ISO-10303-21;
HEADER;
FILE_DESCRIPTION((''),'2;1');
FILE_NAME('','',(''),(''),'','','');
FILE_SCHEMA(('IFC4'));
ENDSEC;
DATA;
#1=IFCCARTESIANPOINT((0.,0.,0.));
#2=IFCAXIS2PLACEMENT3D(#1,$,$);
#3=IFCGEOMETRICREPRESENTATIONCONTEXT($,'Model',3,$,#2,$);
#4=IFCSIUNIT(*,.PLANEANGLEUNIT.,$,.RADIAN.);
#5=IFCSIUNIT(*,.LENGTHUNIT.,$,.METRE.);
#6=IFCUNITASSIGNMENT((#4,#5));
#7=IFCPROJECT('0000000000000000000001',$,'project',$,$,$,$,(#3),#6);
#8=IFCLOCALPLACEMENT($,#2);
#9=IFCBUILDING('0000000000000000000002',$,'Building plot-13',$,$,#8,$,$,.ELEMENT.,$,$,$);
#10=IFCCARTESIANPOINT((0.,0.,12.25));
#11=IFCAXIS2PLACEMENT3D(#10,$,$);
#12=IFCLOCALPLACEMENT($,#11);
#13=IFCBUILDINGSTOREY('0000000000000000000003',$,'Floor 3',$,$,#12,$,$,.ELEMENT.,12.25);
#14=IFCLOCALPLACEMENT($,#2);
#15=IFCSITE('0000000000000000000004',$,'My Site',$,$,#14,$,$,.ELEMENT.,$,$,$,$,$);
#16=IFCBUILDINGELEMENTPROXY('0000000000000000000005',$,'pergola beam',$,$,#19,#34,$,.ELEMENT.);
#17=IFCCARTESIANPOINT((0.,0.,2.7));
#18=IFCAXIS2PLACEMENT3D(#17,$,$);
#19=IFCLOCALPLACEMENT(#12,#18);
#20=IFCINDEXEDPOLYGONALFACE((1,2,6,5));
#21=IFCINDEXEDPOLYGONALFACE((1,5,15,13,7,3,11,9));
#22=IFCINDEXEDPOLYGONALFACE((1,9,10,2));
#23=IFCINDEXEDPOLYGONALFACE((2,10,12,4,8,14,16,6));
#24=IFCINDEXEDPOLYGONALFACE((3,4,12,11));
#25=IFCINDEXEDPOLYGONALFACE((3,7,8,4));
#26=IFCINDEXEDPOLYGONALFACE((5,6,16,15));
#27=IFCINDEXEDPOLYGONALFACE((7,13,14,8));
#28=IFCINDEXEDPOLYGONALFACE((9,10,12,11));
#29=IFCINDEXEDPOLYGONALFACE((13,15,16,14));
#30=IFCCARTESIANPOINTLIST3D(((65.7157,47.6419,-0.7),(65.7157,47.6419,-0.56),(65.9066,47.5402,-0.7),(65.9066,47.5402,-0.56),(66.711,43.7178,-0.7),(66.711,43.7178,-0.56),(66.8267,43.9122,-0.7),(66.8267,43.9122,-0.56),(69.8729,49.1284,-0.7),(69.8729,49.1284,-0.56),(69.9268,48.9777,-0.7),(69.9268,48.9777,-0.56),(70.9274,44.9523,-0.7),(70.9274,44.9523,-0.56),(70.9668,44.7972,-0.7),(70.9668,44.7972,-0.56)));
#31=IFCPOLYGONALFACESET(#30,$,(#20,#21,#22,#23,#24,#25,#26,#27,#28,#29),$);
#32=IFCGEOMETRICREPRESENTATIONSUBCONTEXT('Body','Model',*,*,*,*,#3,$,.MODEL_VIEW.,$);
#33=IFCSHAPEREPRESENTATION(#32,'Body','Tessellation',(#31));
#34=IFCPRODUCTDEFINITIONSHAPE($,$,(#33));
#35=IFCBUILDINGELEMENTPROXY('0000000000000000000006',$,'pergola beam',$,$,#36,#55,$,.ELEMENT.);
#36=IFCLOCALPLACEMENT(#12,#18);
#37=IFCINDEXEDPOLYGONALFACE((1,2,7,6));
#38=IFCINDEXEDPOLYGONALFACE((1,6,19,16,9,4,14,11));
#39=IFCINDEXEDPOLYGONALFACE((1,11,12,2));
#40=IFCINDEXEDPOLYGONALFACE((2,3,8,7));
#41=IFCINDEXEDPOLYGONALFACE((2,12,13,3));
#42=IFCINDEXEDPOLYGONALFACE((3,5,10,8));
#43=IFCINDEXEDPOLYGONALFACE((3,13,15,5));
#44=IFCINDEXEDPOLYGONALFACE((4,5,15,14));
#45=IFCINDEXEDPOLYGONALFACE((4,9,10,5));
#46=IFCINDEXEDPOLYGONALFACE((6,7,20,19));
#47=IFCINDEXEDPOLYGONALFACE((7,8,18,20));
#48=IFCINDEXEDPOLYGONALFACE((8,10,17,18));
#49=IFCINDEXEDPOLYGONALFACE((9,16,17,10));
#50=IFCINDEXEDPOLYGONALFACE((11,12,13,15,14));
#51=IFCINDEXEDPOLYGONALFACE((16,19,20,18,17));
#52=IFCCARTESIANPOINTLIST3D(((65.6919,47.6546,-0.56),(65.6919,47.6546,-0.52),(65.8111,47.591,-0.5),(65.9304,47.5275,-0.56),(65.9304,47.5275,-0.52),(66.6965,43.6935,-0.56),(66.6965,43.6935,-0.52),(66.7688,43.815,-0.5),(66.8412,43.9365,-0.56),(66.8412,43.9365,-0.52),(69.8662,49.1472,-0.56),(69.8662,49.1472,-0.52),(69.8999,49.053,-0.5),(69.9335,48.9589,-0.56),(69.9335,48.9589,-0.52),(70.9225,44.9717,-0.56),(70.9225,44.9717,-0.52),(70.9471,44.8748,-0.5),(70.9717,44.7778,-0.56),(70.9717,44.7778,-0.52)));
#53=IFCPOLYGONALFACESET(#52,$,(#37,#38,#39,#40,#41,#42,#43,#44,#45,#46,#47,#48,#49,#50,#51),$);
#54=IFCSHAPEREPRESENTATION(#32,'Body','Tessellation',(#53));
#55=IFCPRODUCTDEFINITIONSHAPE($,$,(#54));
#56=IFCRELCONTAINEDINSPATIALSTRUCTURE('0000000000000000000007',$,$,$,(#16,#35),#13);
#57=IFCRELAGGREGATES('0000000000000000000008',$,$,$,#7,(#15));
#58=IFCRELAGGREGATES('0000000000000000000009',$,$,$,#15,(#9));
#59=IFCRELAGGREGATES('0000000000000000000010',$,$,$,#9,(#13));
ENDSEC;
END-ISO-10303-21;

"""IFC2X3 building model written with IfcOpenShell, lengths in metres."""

from ifc_helpers import new_model, entity, si_unit, frame, origin, place, context, subcontext, project, spatial, element, save


model = new_model("IFC2X3")

# Units and contexts
model_context = context("Model", 3, world=origin())
body_context = subcontext(model_context, "Body", "Model", "MODEL_VIEW")
ifc_project = project(units=[si_unit("PLANEANGLEUNIT", "RADIAN"), si_unit("LENGTHUNIT", "METRE")], contexts=[model_context])

# Site, building, storey
site_placement = place(None, origin())
site = spatial("IfcSite", under=ifc_project, at=site_placement, Name="My Site", CompositionType="ELEMENT")
building_placement = place(None, origin())
building = spatial("IfcBuilding", under=site, at=building_placement, Name="Building plot-13", CompositionType="ELEMENT")
storey_placement = place(None, frame((0.0, 0.0, 12.25)))
storey = spatial("IfcBuildingStorey", under=building, at=storey_placement, Name="Floor 3", CompositionType="ELEMENT", Elevation=12.25)

# Building element proxies
proxy_1_placement = place(storey_placement, frame((0.0, 0.0, 2.7)))
axis2_placement3_d_1 = entity("IfcAxis2Placement3D", entity("IfcCartesianPoint", [0.0, 0.0, 0.0]))
element("IfcBuildingElementProxy", 1, at=proxy_1_placement, inside=storey, Name="pergola beam", CompositionType="ELEMENT", context=body_context, shape_type="SweptSolid", held_by="IfcProductRepresentation", body=[
    entity("IfcSurfaceCurveSweptAreaSolid", entity("IfcArbitraryClosedProfileDef", "AREA", None, entity("IfcPolyline", [entity("IfcCartesianPoint", [-0.7, -0.08]), entity("IfcCartesianPoint", [-0.7, 0.08]), entity("IfcCartesianPoint", [-0.56, 0.08]), entity("IfcCartesianPoint", [-0.56, -0.08]), entity("IfcCartesianPoint", [-0.7, -0.08])])), axis2_placement3_d_1, entity("IfcPolyline", [entity("IfcCartesianPoint", [69.8999, 49.053]), entity("IfcCartesianPoint", [65.8111, 47.591]), entity("IfcCartesianPoint", [66.7688, 43.815]), entity("IfcCartesianPoint", [70.9471, 44.8748])]), 0.0, 1.0, entity("IfcPlane", axis2_placement3_d_1)),
])
proxy_2_placement = place(storey_placement, frame((0.0, 0.0, 2.7)))
axis2_placement3_d_2 = entity("IfcAxis2Placement3D", entity("IfcCartesianPoint", [0.0, 0.0, 0.0]))
element("IfcBuildingElementProxy", 2, at=proxy_2_placement, inside=storey, Name="pergola beam", CompositionType="ELEMENT", context=body_context, shape_type="SweptSolid", held_by="IfcProductRepresentation", body=[
    entity("IfcSurfaceCurveSweptAreaSolid", entity("IfcArbitraryClosedProfileDef", "AREA", None, entity("IfcPolyline", [entity("IfcCartesianPoint", [-0.5, 0.0]), entity("IfcCartesianPoint", [-0.52, -0.1]), entity("IfcCartesianPoint", [-0.56, -0.1]), entity("IfcCartesianPoint", [-0.56, 0.1]), entity("IfcCartesianPoint", [-0.52, 0.1]), entity("IfcCartesianPoint", [-0.5, 0.0])])), axis2_placement3_d_2, entity("IfcPolyline", [entity("IfcCartesianPoint", [69.8999, 49.053]), entity("IfcCartesianPoint", [65.8111, 47.591]), entity("IfcCartesianPoint", [66.7688, 43.815]), entity("IfcCartesianPoint", [70.9471, 44.8748])]), 0.0, 1.0, entity("IfcPlane", axis2_placement3_d_2)),
])

save(model, "model.ifc")
